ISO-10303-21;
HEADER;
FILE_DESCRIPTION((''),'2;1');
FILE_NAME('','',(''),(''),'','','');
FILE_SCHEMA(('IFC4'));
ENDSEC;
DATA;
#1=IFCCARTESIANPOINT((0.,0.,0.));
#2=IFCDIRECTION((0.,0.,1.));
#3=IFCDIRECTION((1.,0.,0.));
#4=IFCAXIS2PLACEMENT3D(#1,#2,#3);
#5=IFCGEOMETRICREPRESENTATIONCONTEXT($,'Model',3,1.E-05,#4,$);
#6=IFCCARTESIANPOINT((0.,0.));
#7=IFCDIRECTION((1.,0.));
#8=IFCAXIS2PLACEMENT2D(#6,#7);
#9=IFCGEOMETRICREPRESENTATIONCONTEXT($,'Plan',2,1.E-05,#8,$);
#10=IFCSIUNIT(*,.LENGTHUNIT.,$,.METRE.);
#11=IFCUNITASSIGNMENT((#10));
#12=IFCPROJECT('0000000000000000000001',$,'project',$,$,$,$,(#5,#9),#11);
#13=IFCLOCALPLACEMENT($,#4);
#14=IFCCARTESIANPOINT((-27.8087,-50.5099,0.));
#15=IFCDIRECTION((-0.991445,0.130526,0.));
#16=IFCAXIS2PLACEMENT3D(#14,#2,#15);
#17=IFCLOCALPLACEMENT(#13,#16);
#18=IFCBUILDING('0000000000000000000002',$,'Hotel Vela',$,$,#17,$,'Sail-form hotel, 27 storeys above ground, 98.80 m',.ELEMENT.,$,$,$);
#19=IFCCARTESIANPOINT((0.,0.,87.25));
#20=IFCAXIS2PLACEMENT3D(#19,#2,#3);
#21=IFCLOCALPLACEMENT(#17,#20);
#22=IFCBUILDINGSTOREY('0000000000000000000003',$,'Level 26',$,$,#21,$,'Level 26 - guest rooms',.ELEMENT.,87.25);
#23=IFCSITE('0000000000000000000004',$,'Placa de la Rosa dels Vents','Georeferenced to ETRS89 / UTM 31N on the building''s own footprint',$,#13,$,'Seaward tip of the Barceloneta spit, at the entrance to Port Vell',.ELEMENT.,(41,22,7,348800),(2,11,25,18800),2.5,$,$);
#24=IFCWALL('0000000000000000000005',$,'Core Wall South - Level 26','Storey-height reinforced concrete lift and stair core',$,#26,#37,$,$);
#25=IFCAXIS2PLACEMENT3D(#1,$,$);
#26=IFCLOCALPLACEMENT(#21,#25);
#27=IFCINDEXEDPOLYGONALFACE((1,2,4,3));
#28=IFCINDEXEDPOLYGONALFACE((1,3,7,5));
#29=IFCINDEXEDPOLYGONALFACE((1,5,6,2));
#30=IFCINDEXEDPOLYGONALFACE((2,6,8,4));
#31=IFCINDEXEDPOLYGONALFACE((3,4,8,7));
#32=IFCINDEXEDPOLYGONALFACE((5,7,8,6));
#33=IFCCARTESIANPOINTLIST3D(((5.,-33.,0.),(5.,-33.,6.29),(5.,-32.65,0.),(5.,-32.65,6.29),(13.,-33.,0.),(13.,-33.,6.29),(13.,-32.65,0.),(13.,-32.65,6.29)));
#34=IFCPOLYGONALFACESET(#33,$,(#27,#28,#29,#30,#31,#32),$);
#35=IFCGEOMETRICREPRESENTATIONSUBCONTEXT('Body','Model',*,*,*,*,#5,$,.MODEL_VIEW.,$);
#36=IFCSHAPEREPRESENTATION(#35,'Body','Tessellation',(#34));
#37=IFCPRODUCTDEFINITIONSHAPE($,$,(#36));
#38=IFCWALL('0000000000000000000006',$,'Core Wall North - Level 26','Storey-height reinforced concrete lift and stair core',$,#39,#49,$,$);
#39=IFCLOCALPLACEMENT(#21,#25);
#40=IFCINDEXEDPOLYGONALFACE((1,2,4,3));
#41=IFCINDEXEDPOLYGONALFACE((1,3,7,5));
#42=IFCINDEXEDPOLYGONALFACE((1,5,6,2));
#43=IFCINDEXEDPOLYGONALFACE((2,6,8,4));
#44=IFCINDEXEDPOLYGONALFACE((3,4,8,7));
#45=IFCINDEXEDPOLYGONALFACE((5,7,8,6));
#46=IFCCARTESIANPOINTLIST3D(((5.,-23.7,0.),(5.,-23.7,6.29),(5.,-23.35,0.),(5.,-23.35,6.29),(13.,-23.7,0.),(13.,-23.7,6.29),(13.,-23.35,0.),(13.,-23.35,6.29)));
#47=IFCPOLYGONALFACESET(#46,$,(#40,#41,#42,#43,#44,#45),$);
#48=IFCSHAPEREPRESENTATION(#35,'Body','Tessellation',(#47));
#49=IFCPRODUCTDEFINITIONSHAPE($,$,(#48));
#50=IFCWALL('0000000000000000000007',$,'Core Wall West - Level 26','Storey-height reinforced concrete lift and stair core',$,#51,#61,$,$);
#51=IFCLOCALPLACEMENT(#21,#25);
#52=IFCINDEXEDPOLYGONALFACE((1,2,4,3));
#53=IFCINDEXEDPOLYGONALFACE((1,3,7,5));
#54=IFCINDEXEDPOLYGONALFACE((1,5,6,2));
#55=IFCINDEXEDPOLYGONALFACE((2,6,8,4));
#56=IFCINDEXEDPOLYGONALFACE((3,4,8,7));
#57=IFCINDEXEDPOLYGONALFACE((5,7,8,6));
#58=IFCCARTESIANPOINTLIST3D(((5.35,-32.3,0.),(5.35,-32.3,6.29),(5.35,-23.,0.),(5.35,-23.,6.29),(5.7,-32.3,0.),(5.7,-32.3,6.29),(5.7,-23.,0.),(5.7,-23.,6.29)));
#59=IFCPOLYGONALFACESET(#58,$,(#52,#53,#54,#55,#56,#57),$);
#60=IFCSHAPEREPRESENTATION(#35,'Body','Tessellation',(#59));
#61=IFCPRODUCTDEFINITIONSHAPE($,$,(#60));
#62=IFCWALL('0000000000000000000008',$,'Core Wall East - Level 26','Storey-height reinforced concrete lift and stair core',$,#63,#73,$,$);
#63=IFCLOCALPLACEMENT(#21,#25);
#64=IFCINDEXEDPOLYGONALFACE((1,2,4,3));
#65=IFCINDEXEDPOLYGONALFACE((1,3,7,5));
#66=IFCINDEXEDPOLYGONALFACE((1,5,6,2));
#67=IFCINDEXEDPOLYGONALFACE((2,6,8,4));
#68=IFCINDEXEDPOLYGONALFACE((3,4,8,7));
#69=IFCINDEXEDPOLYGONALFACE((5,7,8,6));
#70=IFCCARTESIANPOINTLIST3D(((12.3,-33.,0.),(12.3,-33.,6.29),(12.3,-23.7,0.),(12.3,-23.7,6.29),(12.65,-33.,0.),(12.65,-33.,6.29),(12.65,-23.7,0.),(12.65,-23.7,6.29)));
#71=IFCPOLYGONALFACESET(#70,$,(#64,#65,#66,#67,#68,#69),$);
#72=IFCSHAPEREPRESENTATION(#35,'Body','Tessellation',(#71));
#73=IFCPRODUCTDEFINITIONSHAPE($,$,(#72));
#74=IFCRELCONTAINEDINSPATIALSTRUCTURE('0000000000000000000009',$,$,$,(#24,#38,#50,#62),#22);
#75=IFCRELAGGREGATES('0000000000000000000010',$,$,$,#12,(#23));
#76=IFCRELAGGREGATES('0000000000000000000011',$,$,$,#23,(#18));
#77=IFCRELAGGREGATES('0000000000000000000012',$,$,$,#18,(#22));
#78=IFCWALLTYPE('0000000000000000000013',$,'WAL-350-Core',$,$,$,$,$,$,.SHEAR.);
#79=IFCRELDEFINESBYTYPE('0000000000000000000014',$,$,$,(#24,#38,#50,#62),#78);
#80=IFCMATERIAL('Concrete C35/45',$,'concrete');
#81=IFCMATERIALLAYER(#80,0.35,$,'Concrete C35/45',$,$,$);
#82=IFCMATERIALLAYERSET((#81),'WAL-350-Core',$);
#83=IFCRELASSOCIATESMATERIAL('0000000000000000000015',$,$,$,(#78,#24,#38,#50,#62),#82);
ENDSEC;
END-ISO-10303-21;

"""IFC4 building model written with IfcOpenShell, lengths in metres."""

from ifc_helpers import new_model, si_unit, frame, origin_with_axes, origin_2d_with_axis, place, context, subcontext, project, spatial, line, indexed_curve, outline, extrude, material, layer, layer_set, layer_usage, type_object, element, save


model = new_model("IFC4")

# Units and contexts
model_context = context("Model", 3, precision=1e-05, world=origin_with_axes())
plan_context = context("Plan", 2, precision=1e-05, world=origin_2d_with_axis())
body_context = subcontext(model_context, "Body", "Model", "MODEL_VIEW")
ifc_project = project(units=[si_unit("LENGTHUNIT", "METRE")], contexts=[model_context, plan_context])

# Site, building, storey
site_placement = place(None, origin_with_axes())
site = spatial("IfcSite", under=ifc_project, at=site_placement, Name="Placa de la Rosa dels Vents", Description="Georeferenced to ETRS89 / UTM 31N on the building's own footprint", LongName="Seaward tip of the Barceloneta spit, at the entrance to Port Vell", CompositionType="ELEMENT", RefLatitude=(41, 22, 7, 348800), RefLongitude=(2, 11, 25, 18800), RefElevation=2.5)
building_placement = place(site_placement, frame((-27.8087, -50.5099, 0.0), z_axis=(0.0, 0.0, 1.0), x_axis=(-0.991445, 0.130526, 0.0)))
building = spatial("IfcBuilding", under=site, at=building_placement, Name="Hotel Vela", LongName="Sail-form hotel, 27 storeys above ground, 98.80 m", CompositionType="ELEMENT")
storey_placement = place(building_placement, frame((0.0, 0.0, 87.25), z_axis=(0.0, 0.0, 1.0), x_axis=(1.0, 0.0, 0.0)))
storey = spatial("IfcBuildingStorey", under=building, at=storey_placement, Name="Level 26", LongName="Level 26 - guest rooms", CompositionType="ELEMENT", Elevation=87.25)

# Shared definitions
ifc_material = material(Name="Concrete C35/45", Category="concrete")

# Walls
ifc_layer_1 = layer(ifc_material, 0.35, Name="Concrete C35/45")
ifc_layer_set_1 = layer_set([ifc_layer_1], Name="WAL-350-Core")
ifc_layer_usage_1 = layer_usage(ifc_layer_set_1, "AXIS2", "POSITIVE", 0.0)
wall_type = type_object("IfcWallType", Name="WAL-350-Core", PredefinedType="SHEAR", material=ifc_layer_set_1)
wall_1_placement = place(storey_placement, frame((5.0, -33.0, 0.0), z_axis=(0.0, 0.0, 1.0), x_axis=(1.0, 0.0, 0.0)))
element("IfcWall", 1, at=wall_1_placement, inside=storey, type_object=wall_type, material=ifc_layer_usage_1, Name="Core Wall South - Level 26", Description="Storey-height reinforced concrete lift and stair core", context=body_context, shape_type="SweptSolid", body=[
    extrude(outline(indexed_curve([(0.0, 0.0), (8.0, 0.0), (8.0, 0.35), (0.0, 0.35)], segments=[line(1, 2, 3, 4, 1)])), origin_with_axes(), (0.0, 0.0, 1.0), 6.29),
])
ifc_layer_usage_2 = layer_usage(ifc_layer_set_1, "AXIS2", "POSITIVE", 0.0)
wall_2_placement = place(storey_placement, frame((13.0, -23.35, 0.0), z_axis=(0.0, 0.0, 1.0), x_axis=(-1.0, 0.0, 0.0)))
element("IfcWall", 2, at=wall_2_placement, inside=storey, type_object=wall_type, material=ifc_layer_usage_2, Name="Core Wall North - Level 26", Description="Storey-height reinforced concrete lift and stair core", context=body_context, shape_type="SweptSolid", body=[
    extrude(outline(indexed_curve([(0.0, 0.0), (8.0, 0.0), (8.0, 0.35), (0.0, 0.35)], segments=[line(1, 2, 3, 4, 1)])), origin_with_axes(), (0.0, 0.0, 1.0), 6.29),
])
ifc_layer_usage_3 = layer_usage(ifc_layer_set_1, "AXIS2", "POSITIVE", 0.0)
wall_3_placement = place(storey_placement, frame((5.35, -23.0, 0.0), z_axis=(0.0, 0.0, 1.0), x_axis=(0.0, -1.0, 0.0)))
element("IfcWall", 3, at=wall_3_placement, inside=storey, type_object=wall_type, material=ifc_layer_usage_3, Name="Core Wall West - Level 26", Description="Storey-height reinforced concrete lift and stair core", context=body_context, shape_type="SweptSolid", body=[
    extrude(outline(indexed_curve([(0.0, 0.0), (9.3, 0.0), (9.3, 0.35), (0.0, 0.35)], segments=[line(1, 2, 3, 4, 1)])), origin_with_axes(), (0.0, 0.0, 1.0), 6.29),
])
ifc_layer_usage_4 = layer_usage(ifc_layer_set_1, "AXIS2", "POSITIVE", 0.0)
wall_4_placement = place(storey_placement, frame((12.65, -33.0, 0.0), z_axis=(0.0, 0.0, 1.0), x_axis=(0.0, 1.0, 0.0)))
element("IfcWall", 4, at=wall_4_placement, inside=storey, type_object=wall_type, material=ifc_layer_usage_4, Name="Core Wall East - Level 26", Description="Storey-height reinforced concrete lift and stair core", context=body_context, shape_type="SweptSolid", body=[
    extrude(outline(indexed_curve([(0.0, 0.0), (9.3, 0.0), (9.3, 0.35), (0.0, 0.35)], segments=[line(1, 2, 3, 4, 1)])), origin_with_axes(), (0.0, 0.0, 1.0), 6.29),
])

save(model, "model.ifc")
